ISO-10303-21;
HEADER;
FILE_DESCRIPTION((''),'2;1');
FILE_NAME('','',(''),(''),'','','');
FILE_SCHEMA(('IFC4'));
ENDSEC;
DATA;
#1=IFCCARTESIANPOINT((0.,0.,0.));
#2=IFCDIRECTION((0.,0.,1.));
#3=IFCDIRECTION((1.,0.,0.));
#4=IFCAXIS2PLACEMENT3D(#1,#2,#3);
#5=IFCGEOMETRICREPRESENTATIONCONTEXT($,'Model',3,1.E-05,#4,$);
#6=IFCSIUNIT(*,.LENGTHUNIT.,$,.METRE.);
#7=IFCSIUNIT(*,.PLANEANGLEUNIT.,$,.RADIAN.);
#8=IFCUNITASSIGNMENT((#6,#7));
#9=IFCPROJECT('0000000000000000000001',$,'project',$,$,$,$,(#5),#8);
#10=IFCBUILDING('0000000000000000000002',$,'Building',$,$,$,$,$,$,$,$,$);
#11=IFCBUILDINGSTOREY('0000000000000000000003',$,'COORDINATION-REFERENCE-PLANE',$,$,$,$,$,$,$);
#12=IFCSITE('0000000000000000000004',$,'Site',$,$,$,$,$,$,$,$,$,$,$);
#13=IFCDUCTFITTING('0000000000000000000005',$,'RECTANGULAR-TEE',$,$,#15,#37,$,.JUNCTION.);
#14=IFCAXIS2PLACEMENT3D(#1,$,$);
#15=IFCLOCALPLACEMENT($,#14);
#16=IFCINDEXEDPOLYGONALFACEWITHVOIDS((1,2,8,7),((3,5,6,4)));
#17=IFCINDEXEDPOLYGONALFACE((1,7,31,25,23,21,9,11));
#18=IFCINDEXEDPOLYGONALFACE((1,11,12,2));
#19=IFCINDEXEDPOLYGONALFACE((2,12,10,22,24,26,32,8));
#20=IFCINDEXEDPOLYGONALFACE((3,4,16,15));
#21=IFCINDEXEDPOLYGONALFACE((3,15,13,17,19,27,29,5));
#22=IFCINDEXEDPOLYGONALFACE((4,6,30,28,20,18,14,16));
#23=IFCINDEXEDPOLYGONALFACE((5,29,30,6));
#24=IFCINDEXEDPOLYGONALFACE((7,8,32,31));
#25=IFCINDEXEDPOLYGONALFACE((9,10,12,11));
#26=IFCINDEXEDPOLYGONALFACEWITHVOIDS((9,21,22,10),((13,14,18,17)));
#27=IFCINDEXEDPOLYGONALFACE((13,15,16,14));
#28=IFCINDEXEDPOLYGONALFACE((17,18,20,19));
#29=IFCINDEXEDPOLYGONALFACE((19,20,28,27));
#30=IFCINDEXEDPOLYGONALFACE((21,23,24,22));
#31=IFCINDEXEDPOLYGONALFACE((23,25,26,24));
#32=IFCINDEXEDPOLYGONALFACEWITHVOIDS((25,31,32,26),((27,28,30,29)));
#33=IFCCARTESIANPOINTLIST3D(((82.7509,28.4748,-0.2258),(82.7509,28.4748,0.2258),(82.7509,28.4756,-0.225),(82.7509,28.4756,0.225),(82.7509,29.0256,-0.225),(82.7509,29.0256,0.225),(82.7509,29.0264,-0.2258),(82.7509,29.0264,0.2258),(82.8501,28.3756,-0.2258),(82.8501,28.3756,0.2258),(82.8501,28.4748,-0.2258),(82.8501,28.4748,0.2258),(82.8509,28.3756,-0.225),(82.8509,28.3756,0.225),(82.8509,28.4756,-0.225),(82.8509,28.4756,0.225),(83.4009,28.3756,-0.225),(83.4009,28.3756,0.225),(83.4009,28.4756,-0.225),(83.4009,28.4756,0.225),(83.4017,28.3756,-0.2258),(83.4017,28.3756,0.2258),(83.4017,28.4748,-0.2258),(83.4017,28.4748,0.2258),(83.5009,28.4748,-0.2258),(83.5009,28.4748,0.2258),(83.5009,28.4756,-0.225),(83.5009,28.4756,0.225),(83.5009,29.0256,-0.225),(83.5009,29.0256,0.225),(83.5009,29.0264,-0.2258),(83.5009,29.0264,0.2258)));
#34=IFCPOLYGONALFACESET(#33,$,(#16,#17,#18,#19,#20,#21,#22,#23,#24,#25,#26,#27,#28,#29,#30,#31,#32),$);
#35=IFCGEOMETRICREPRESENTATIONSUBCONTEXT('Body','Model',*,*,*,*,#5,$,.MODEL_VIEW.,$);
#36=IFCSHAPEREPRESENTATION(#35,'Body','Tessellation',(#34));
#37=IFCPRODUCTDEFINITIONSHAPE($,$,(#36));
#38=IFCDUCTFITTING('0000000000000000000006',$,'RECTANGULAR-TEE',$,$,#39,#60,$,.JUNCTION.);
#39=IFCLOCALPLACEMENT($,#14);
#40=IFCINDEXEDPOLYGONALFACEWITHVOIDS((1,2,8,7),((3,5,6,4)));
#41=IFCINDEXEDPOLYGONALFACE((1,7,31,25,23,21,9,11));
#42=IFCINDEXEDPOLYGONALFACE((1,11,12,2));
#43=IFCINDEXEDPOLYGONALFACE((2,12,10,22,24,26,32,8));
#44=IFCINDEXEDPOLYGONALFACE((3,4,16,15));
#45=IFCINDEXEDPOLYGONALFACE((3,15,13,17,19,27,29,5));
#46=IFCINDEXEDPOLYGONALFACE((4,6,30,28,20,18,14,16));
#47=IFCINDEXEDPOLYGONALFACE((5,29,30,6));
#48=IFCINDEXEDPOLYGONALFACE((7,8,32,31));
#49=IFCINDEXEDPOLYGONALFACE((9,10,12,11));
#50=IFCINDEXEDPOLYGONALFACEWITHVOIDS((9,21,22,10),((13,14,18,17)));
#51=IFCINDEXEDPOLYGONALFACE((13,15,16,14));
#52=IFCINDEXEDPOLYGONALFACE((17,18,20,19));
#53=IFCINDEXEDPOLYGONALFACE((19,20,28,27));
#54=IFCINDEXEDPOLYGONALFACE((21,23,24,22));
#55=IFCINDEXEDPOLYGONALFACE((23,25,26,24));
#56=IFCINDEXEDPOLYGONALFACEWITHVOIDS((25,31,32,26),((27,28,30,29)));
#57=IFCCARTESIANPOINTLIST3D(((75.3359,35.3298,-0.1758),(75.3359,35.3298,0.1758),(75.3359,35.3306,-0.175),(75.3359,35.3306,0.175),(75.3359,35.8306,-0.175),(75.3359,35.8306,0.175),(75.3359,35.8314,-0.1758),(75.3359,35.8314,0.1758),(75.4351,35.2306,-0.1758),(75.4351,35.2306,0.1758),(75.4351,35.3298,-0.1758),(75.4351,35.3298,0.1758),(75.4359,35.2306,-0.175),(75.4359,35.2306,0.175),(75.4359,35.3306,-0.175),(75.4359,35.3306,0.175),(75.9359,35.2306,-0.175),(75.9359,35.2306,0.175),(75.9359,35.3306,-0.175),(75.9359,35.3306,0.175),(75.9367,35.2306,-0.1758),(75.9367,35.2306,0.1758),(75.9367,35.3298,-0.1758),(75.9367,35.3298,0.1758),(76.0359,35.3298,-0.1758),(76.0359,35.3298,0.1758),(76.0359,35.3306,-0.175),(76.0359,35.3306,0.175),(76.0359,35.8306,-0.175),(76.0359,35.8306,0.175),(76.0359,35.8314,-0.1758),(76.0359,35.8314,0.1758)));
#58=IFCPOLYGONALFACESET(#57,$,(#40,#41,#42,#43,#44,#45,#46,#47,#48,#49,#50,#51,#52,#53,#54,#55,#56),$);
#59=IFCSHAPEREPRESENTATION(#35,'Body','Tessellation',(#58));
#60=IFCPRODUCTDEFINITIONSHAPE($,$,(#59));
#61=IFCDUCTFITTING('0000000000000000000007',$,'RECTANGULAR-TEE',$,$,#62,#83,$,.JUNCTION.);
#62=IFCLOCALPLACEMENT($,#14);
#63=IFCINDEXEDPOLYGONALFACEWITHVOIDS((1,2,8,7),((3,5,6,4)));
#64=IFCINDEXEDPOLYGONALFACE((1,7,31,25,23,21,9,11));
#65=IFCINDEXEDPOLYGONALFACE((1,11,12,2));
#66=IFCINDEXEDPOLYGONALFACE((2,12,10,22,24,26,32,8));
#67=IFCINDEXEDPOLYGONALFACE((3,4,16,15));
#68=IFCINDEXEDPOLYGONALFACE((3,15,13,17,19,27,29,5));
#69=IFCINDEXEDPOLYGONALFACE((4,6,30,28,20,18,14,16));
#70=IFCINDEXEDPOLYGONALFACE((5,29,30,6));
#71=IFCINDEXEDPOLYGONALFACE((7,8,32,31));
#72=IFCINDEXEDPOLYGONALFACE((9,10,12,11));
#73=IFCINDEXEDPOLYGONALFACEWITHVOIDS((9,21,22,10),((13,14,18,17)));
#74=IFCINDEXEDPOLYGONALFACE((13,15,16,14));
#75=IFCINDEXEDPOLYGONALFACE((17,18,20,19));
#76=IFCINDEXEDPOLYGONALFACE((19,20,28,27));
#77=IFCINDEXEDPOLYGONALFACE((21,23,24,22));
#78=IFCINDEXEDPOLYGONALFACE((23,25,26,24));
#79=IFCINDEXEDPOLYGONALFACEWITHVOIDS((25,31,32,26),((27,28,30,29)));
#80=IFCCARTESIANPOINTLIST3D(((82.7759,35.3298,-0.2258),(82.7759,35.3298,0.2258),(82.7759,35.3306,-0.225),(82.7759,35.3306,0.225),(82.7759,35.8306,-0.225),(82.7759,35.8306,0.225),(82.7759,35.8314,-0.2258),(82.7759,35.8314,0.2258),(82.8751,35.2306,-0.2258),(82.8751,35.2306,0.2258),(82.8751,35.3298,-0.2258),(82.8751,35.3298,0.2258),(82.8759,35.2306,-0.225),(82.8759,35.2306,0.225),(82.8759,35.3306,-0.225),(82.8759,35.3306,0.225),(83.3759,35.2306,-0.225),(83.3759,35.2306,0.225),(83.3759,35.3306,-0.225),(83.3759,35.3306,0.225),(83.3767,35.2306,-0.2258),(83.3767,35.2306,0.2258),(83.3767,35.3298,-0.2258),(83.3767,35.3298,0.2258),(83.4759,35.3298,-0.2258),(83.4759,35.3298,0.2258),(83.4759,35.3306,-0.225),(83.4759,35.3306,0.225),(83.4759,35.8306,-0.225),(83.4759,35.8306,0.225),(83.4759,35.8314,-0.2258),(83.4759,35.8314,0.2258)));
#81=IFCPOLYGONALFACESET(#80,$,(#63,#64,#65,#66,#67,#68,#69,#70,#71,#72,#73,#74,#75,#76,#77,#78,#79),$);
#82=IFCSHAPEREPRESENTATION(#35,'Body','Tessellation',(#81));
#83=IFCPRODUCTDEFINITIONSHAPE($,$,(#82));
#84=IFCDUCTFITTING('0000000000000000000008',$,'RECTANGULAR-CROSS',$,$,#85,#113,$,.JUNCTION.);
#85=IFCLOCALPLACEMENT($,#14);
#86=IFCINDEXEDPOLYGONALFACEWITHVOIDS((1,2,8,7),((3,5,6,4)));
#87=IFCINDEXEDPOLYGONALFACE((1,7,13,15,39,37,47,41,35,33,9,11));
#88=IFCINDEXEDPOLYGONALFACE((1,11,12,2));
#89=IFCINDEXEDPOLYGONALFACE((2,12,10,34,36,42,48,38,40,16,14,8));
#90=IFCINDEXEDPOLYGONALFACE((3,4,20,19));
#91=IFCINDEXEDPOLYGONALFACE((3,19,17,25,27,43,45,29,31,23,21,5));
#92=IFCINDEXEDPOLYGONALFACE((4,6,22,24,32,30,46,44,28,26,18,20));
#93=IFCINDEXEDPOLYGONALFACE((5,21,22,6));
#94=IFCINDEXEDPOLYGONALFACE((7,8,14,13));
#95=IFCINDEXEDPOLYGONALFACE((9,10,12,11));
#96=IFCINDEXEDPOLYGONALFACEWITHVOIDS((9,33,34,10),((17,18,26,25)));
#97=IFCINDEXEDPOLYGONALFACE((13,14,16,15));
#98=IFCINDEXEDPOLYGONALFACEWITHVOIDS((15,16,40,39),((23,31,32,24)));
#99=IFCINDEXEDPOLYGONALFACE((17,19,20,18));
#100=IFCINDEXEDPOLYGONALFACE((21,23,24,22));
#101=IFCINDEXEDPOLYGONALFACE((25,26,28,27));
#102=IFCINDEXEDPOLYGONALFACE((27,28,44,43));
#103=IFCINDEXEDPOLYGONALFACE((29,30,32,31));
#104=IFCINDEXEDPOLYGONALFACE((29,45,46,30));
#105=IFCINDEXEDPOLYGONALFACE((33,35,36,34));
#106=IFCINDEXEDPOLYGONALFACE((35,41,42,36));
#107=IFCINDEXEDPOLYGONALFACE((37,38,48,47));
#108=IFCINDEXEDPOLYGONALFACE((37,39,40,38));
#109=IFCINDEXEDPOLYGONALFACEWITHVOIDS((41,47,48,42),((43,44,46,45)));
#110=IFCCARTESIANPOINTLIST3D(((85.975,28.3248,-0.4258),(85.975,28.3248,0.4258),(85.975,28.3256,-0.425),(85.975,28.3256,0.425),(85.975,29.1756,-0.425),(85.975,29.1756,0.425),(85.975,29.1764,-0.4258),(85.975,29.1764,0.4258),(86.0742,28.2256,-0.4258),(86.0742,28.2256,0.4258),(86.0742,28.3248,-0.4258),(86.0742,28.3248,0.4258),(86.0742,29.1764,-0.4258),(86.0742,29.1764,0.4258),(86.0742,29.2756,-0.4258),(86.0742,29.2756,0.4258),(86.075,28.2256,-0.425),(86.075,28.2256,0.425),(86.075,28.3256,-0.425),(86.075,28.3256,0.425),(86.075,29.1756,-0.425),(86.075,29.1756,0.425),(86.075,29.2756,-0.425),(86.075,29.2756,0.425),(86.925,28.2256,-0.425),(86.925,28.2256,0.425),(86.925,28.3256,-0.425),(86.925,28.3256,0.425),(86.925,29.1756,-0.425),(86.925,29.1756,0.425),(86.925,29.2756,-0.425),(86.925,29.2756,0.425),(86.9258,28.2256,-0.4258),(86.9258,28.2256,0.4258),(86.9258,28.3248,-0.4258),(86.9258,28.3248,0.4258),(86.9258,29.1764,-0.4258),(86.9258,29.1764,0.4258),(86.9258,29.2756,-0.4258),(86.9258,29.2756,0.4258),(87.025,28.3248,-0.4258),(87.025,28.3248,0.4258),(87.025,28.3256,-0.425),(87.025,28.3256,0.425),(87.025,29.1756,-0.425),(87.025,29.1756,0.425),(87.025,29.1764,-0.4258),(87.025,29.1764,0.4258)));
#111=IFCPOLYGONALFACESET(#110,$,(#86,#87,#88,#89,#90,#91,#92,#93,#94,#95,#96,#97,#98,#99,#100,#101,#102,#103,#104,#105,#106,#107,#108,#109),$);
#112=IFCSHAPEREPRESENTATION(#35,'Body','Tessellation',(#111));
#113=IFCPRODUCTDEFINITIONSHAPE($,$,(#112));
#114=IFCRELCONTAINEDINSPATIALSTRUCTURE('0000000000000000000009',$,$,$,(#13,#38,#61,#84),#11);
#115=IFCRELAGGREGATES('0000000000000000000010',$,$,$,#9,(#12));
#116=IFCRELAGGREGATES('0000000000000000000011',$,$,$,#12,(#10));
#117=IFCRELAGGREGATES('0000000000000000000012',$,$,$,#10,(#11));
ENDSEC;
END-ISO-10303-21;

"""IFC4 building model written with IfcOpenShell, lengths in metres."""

from ifc_helpers import new_model, si_unit, frame, origin_with_axes, place, context, subcontext, project, spatial, rectangle, extrude, boolean, element, save


model = new_model("IFC4")

# Units and contexts
model_context = context("Model", 3, precision=1e-05, world=origin_with_axes())
body_context = subcontext(model_context, "Body", "Model", "MODEL_VIEW")
ifc_project = project(units=[si_unit("LENGTHUNIT", "METRE"), si_unit("PLANEANGLEUNIT", "RADIAN")], contexts=[model_context])

# Site, building, storey
site = spatial("IfcSite", under=ifc_project, Name="Site")
building = spatial("IfcBuilding", under=site, Name="Building")
storey = spatial("IfcBuildingStorey", under=building, Name="COORDINATION-REFERENCE-PLANE")

# Duct fittings
duct_fitting_1_placement = place(None, frame((83.1259, 28.7506, 0.0), z_axis=(-1.0, 0.0, 0.0), x_axis=(0.0, -1.0, 0.0)))
solid_1 = boolean("UNION", extrude(rectangle(XDim=0.55, YDim=0.45), frame((0.0, 0.0, -0.375), z_axis=(0.0, 0.0, 1.0), x_axis=(1.0, 0.0, 0.0)), (0.0, 0.0, 1.0), 0.75), extrude(rectangle(XDim=0.55, YDim=0.45), frame((0.0, 0.0, 0.0), z_axis=(1.0, 0.0, 0.0), x_axis=(0.0, 0.0, -1.0)), (0.0, 0.0, 1.0), 0.375))
element("IfcDuctFitting", 1, at=duct_fitting_1_placement, inside=storey, Name="RECTANGULAR-TEE", PredefinedType="JUNCTION", context=body_context, shape_type="CSG", body=[
    boolean("DIFFERENCE", boolean("UNION", extrude(rectangle(XDim=0.5516, YDim=0.4516), frame((0.0, 0.0, -0.375), z_axis=(0.0, 0.0, 1.0), x_axis=(1.0, 0.0, 0.0)), (0.0, 0.0, 1.0), 0.75), extrude(rectangle(XDim=0.5516, YDim=0.4516), frame((0.0, 0.0, 0.0), z_axis=(1.0, 0.0, 0.0), x_axis=(0.0, 0.0, -1.0)), (0.0, 0.0, 1.0), 0.375)), solid_1),
])
duct_fitting_2_placement = place(None, frame((75.6859, 35.5806, 0.0), z_axis=(-1.0, 0.0, 0.0), x_axis=(0.0, -1.0, 0.0)))
solid_2 = boolean("UNION", extrude(rectangle(XDim=0.5, YDim=0.35), frame((0.0, 0.0, -0.35), z_axis=(0.0, 0.0, 1.0), x_axis=(1.0, 0.0, 0.0)), (0.0, 0.0, 1.0), 0.7), extrude(rectangle(XDim=0.5, YDim=0.35), frame((0.0, 0.0, 0.0), z_axis=(1.0, 0.0, 0.0), x_axis=(0.0, 0.0, -1.0)), (0.0, 0.0, 1.0), 0.35))
element("IfcDuctFitting", 2, at=duct_fitting_2_placement, inside=storey, Name="RECTANGULAR-TEE", PredefinedType="JUNCTION", context=body_context, shape_type="CSG", body=[
    boolean("DIFFERENCE", boolean("UNION", extrude(rectangle(XDim=0.5016, YDim=0.3516), frame((0.0, 0.0, -0.35), z_axis=(0.0, 0.0, 1.0), x_axis=(1.0, 0.0, 0.0)), (0.0, 0.0, 1.0), 0.7), extrude(rectangle(XDim=0.5016, YDim=0.3516), frame((0.0, 0.0, 0.0), z_axis=(1.0, 0.0, 0.0), x_axis=(0.0, 0.0, -1.0)), (0.0, 0.0, 1.0), 0.35)), solid_2),
])
duct_fitting_3_placement = place(None, frame((83.1259, 35.5806, 0.0), z_axis=(-1.0, 0.0, 0.0), x_axis=(0.0, -1.0, 0.0)))
solid_3 = boolean("UNION", extrude(rectangle(XDim=0.5, YDim=0.45), frame((0.0, 0.0, -0.35), z_axis=(0.0, 0.0, 1.0), x_axis=(1.0, 0.0, 0.0)), (0.0, 0.0, 1.0), 0.7), extrude(rectangle(XDim=0.5, YDim=0.45), frame((0.0, 0.0, 0.0), z_axis=(1.0, 0.0, 0.0), x_axis=(0.0, 0.0, -1.0)), (0.0, 0.0, 1.0), 0.35))
element("IfcDuctFitting", 3, at=duct_fitting_3_placement, inside=storey, Name="RECTANGULAR-TEE", PredefinedType="JUNCTION", context=body_context, shape_type="CSG", body=[
    boolean("DIFFERENCE", boolean("UNION", extrude(rectangle(XDim=0.5016, YDim=0.4516), frame((0.0, 0.0, -0.35), z_axis=(0.0, 0.0, 1.0), x_axis=(1.0, 0.0, 0.0)), (0.0, 0.0, 1.0), 0.7), extrude(rectangle(XDim=0.5016, YDim=0.4516), frame((0.0, 0.0, 0.0), z_axis=(1.0, 0.0, 0.0), x_axis=(0.0, 0.0, -1.0)), (0.0, 0.0, 1.0), 0.35)), solid_3),
])
duct_fitting_4_placement = place(None, frame((86.5, 28.7506, 0.0), z_axis=(0.0, -1.0, 0.0), x_axis=(1.0, 0.0, 0.0)))
solid_4 = boolean("UNION", extrude(rectangle(XDim=0.85, YDim=0.85), frame((0.0, 0.0, -0.525), z_axis=(0.0, 0.0, 1.0), x_axis=(1.0, 0.0, 0.0)), (0.0, 0.0, 1.0), 1.05), extrude(rectangle(XDim=0.85, YDim=0.85), frame((-0.525, 0.0, 0.0), z_axis=(1.0, 0.0, 0.0), x_axis=(0.0, 0.0, -1.0)), (0.0, 0.0, 1.0), 1.05))
element("IfcDuctFitting", 4, at=duct_fitting_4_placement, inside=storey, Name="RECTANGULAR-CROSS", PredefinedType="JUNCTION", context=body_context, shape_type="CSG", body=[
    boolean("DIFFERENCE", boolean("UNION", extrude(rectangle(XDim=0.8516, YDim=0.8516), frame((0.0, 0.0, -0.525), z_axis=(0.0, 0.0, 1.0), x_axis=(1.0, 0.0, 0.0)), (0.0, 0.0, 1.0), 1.05), extrude(rectangle(XDim=0.8516, YDim=0.8516), frame((-0.525, 0.0, 0.0), z_axis=(1.0, 0.0, 0.0), x_axis=(0.0, 0.0, -1.0)), (0.0, 0.0, 1.0), 1.05)), solid_4),
])

save(model, "model.ifc")
